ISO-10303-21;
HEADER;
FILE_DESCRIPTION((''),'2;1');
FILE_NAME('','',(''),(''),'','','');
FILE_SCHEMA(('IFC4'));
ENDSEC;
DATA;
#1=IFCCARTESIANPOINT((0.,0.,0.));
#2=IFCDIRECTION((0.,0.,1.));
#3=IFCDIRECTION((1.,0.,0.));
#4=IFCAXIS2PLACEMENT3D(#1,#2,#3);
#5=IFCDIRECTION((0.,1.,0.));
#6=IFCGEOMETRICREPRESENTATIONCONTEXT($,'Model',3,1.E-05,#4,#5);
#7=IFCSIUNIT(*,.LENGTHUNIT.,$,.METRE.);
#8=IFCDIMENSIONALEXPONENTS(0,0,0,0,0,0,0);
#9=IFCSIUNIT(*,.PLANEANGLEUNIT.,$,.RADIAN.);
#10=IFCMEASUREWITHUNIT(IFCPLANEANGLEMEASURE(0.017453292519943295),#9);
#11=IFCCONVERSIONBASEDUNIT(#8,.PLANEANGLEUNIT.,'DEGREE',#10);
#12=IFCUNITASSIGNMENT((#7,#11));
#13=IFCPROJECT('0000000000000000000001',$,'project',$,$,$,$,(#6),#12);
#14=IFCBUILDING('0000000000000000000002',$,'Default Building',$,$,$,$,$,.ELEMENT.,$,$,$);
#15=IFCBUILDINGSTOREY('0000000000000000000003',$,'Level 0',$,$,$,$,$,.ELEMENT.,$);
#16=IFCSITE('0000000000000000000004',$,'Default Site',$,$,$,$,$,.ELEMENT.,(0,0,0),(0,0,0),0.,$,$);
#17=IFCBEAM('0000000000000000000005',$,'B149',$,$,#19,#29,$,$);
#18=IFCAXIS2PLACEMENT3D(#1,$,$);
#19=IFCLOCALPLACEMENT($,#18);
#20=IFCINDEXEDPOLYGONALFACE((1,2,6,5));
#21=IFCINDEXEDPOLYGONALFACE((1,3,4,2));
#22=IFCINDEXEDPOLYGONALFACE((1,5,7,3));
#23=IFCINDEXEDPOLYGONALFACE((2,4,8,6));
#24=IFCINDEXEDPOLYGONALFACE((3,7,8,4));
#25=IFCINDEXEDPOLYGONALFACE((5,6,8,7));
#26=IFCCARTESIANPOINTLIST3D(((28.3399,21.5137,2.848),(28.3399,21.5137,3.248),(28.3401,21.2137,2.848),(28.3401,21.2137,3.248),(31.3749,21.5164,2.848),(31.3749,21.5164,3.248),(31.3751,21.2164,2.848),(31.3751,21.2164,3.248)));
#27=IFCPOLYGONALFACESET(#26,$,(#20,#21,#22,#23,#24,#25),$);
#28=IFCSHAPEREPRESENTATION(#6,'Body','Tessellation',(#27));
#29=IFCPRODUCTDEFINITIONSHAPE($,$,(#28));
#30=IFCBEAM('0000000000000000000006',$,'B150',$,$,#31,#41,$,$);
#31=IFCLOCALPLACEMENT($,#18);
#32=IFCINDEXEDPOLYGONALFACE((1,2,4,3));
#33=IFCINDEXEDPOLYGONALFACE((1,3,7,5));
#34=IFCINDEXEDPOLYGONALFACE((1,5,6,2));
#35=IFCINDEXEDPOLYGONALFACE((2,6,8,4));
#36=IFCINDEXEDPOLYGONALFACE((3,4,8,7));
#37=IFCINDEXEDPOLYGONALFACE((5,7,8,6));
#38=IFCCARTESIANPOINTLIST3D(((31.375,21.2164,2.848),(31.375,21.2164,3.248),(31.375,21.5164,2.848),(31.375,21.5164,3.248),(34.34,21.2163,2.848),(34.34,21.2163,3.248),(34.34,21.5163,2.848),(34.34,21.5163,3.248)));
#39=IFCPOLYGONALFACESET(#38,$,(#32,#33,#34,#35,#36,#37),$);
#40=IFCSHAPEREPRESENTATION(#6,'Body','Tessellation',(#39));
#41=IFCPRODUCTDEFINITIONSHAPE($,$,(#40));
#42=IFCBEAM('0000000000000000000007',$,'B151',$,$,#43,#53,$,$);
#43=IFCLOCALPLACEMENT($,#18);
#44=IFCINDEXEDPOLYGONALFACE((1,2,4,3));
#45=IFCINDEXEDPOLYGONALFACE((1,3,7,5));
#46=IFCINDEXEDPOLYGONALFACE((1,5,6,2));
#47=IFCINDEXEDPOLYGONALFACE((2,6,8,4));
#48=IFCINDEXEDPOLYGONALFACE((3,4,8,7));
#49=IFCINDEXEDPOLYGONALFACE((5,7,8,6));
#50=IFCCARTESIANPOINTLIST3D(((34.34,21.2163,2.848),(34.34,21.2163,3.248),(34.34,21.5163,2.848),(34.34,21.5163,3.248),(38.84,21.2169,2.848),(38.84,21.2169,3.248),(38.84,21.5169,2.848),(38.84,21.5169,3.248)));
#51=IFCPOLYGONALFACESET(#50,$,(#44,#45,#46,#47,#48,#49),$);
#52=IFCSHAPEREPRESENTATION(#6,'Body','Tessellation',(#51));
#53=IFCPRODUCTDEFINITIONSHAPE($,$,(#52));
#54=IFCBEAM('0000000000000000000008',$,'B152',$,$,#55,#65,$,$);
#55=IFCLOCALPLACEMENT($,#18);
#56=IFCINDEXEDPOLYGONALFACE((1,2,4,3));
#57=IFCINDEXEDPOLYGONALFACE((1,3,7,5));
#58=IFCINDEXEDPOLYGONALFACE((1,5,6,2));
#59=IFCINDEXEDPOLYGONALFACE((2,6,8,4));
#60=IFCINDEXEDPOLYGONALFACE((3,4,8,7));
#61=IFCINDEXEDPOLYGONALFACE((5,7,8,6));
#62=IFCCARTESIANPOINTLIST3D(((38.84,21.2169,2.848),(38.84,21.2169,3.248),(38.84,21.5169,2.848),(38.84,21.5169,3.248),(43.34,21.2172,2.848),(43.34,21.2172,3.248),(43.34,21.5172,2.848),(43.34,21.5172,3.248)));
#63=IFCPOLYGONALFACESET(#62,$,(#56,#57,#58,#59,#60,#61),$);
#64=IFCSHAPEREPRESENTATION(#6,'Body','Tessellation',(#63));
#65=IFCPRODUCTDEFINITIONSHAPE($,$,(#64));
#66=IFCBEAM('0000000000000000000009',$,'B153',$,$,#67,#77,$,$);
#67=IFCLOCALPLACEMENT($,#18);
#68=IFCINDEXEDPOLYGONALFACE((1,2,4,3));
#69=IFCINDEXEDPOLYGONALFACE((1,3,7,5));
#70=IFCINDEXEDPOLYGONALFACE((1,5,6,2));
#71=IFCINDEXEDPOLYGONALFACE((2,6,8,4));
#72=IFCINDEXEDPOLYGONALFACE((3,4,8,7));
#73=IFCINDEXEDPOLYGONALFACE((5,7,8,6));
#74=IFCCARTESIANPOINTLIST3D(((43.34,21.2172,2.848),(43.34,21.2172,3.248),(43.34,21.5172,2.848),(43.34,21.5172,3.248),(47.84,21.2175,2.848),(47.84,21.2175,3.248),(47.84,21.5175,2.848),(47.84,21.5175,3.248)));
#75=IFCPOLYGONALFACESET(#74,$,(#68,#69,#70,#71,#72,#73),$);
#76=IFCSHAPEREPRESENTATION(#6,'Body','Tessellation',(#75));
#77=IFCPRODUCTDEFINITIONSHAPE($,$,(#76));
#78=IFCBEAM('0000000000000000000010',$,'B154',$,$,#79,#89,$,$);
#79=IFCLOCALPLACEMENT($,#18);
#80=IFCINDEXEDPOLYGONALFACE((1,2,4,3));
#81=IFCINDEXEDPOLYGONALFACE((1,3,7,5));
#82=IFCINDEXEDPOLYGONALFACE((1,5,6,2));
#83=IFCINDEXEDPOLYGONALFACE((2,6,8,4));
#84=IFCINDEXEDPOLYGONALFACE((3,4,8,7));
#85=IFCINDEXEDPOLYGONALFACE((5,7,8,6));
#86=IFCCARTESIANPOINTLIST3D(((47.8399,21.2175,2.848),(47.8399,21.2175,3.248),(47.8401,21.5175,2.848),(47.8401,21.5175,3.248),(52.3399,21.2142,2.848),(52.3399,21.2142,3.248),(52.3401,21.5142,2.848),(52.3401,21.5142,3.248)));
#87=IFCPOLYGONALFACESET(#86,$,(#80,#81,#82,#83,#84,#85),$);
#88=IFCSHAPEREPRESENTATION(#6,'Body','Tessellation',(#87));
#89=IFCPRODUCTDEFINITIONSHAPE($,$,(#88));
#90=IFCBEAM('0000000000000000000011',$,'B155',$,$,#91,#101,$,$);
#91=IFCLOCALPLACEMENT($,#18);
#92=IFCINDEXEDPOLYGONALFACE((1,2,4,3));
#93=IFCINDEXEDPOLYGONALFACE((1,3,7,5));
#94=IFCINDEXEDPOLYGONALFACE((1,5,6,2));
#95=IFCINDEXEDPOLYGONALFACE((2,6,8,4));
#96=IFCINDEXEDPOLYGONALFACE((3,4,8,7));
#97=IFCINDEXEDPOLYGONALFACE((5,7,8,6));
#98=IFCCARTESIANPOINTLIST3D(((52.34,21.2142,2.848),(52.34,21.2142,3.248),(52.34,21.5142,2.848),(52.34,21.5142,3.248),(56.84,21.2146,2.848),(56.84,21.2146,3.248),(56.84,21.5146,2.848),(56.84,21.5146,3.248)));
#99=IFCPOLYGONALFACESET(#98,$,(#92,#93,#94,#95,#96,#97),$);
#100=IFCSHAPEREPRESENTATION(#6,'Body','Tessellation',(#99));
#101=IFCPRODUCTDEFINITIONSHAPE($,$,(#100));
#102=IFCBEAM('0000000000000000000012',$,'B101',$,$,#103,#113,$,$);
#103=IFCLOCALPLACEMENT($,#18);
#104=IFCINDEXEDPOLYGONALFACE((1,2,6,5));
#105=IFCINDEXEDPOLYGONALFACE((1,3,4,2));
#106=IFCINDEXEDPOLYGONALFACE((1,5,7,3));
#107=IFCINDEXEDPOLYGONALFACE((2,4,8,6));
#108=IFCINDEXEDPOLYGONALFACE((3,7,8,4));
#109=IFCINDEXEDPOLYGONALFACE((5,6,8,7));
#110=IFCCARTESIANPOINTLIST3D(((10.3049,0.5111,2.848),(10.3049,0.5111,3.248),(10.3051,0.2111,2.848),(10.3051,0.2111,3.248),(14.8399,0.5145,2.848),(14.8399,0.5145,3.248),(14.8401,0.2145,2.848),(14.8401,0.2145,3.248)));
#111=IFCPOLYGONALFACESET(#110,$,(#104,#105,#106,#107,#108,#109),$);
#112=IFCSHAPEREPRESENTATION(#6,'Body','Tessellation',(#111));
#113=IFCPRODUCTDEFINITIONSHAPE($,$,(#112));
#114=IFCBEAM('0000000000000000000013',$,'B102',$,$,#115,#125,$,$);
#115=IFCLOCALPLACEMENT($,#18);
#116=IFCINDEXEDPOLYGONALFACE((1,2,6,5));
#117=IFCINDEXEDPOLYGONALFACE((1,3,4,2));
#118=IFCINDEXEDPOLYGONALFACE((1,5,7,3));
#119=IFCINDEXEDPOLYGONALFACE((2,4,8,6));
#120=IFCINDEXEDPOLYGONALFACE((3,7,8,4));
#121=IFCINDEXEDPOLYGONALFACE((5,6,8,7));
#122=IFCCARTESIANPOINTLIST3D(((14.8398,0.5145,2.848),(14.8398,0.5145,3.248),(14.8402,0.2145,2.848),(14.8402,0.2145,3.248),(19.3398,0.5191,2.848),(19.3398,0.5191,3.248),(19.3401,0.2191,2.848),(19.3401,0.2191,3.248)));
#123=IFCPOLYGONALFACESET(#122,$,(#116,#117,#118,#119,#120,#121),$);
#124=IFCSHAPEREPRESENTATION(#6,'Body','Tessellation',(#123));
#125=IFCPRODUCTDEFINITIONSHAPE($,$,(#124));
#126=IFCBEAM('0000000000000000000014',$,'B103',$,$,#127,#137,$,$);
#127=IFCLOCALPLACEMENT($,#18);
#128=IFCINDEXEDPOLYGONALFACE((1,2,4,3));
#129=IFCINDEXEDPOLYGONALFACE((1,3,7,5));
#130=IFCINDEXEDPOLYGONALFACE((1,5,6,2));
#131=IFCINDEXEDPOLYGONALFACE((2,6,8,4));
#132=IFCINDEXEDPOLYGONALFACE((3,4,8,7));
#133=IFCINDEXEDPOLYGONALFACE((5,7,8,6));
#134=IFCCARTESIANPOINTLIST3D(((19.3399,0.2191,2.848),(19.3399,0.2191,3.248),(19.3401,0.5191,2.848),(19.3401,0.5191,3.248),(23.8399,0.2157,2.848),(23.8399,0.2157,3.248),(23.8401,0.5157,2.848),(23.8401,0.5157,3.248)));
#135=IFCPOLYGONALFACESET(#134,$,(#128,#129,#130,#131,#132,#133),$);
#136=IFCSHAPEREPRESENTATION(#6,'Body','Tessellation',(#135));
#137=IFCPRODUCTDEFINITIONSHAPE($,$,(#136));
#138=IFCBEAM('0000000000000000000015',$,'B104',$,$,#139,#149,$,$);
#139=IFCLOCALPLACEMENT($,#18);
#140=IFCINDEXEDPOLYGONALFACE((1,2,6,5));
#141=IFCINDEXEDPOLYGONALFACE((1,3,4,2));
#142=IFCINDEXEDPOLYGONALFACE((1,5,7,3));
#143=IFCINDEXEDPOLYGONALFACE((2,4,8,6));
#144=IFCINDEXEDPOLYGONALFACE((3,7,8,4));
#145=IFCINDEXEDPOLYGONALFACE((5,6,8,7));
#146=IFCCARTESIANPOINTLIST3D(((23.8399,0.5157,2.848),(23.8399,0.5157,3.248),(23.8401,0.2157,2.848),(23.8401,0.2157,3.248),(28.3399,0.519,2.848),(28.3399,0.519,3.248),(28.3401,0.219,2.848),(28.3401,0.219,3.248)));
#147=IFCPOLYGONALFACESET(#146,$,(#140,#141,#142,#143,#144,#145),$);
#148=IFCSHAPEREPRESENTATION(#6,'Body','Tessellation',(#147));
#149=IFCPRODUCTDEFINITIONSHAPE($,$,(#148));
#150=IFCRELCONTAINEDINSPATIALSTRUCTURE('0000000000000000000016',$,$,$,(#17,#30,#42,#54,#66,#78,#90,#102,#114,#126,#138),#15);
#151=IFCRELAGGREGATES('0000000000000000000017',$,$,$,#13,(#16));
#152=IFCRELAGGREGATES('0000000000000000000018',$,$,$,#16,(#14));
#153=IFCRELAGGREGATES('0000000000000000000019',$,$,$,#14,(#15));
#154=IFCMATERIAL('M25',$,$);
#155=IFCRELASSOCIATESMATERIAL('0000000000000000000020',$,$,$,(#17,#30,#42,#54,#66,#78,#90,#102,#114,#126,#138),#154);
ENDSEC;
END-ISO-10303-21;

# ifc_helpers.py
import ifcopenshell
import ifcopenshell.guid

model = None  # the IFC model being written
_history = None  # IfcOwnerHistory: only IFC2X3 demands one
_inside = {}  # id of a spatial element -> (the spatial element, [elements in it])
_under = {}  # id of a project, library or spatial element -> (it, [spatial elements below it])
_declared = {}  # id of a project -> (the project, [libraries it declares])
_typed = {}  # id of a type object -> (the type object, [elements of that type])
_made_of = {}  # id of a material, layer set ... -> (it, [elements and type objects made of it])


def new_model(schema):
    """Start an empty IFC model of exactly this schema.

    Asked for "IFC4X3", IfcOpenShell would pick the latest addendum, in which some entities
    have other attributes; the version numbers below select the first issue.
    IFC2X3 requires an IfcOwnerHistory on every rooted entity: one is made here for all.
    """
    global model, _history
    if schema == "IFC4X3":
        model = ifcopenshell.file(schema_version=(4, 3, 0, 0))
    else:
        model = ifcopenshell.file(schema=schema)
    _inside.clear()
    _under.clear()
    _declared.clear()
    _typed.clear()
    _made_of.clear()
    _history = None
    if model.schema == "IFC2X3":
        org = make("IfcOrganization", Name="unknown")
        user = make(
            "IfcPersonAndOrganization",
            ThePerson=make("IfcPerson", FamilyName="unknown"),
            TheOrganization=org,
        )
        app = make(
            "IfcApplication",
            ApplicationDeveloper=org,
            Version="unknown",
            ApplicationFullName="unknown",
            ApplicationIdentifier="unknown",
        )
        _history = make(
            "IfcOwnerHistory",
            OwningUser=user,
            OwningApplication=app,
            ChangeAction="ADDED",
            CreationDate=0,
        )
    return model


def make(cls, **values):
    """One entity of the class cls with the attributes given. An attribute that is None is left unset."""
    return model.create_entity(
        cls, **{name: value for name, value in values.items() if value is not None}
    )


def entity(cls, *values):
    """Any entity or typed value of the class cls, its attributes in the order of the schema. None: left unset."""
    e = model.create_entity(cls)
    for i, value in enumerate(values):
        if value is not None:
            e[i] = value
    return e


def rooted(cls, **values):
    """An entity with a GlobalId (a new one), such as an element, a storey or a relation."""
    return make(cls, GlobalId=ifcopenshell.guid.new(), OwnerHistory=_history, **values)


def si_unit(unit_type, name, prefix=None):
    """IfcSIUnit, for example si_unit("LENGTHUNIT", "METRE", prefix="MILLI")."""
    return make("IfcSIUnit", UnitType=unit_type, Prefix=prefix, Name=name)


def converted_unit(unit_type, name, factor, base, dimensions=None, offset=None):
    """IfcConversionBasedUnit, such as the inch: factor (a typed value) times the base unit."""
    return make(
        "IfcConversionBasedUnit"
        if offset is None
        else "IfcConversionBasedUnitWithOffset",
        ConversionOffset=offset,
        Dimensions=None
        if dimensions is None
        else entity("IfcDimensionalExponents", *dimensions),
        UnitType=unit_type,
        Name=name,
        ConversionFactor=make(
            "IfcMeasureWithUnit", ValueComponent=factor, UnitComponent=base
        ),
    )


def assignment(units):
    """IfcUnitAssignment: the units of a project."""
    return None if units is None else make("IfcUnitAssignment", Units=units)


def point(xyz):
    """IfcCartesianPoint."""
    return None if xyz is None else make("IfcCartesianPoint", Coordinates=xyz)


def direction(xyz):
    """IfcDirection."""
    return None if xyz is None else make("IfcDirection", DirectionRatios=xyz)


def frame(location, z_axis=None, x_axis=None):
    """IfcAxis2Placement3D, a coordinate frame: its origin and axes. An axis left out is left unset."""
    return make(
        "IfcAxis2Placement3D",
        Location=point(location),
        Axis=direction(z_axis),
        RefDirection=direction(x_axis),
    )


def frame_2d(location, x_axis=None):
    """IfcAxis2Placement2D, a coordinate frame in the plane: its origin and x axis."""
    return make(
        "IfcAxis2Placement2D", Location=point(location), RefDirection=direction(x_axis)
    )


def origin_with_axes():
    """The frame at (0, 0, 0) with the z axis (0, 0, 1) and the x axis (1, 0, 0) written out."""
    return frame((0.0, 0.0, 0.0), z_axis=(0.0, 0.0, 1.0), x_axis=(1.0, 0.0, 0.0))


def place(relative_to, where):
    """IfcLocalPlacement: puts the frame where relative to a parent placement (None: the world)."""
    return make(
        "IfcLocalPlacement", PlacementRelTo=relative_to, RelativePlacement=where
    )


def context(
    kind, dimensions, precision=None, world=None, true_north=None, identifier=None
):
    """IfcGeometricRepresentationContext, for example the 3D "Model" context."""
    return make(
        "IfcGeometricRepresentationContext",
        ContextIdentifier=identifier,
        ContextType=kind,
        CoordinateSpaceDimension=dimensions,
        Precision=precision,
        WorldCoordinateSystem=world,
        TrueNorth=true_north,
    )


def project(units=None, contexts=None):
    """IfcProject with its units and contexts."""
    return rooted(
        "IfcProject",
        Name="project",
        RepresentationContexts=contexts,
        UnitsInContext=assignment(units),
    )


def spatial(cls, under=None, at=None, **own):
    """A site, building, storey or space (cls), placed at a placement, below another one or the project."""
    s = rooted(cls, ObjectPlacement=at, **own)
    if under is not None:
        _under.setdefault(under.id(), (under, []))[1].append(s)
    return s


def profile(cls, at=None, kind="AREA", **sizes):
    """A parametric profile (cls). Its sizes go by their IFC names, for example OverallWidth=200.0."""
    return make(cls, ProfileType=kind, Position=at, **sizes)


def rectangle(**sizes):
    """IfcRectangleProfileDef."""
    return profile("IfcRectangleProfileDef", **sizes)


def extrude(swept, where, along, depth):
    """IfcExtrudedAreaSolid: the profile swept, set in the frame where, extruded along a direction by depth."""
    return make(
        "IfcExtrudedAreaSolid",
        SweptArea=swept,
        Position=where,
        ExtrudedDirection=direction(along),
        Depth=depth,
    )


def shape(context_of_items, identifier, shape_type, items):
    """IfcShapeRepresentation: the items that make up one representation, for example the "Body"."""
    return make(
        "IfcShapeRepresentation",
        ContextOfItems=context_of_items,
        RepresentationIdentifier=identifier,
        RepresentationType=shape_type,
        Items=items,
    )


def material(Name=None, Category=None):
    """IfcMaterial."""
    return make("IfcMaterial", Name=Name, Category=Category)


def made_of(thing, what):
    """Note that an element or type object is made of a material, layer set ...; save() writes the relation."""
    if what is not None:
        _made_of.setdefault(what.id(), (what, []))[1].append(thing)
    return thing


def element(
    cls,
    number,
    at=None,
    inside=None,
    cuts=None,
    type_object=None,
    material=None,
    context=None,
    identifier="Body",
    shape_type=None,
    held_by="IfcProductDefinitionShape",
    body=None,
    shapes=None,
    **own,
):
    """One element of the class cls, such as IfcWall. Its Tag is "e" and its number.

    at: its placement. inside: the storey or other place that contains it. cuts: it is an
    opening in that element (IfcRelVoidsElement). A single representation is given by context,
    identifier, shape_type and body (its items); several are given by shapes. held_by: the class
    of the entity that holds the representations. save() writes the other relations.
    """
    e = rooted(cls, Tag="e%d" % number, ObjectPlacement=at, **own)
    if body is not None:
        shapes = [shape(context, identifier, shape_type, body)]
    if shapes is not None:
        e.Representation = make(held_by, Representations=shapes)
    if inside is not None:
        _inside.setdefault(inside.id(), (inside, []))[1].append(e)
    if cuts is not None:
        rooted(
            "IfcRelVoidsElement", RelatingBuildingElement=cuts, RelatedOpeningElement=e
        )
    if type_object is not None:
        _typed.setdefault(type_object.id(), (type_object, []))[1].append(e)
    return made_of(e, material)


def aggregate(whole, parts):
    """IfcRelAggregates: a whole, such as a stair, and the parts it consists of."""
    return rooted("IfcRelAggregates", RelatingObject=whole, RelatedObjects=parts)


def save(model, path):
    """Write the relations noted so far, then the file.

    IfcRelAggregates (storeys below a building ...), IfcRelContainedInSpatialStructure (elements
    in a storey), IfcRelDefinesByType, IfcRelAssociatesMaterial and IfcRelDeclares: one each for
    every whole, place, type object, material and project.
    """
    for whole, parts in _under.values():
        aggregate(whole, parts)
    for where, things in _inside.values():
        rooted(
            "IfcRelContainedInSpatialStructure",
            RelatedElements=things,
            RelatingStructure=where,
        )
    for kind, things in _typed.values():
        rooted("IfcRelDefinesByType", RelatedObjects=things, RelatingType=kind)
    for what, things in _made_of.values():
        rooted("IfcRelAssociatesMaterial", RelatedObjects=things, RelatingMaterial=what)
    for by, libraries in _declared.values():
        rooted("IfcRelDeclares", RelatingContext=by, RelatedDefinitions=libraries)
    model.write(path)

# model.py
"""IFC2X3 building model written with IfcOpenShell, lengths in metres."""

from ifc_helpers import new_model, entity, si_unit, converted_unit, direction, frame, frame_2d, origin_with_axes, place, context, project, spatial, rectangle, extrude, material, element, save


model = new_model("IFC2X3")

# Units and contexts
model_context = context("Model", 3, precision=1e-05, world=origin_with_axes(), true_north=direction((0.0, 1.0, 0.0)))
ifc_project = project(units=[si_unit("LENGTHUNIT", "METRE"), converted_unit("PLANEANGLEUNIT", "DEGREE", entity("IfcPlaneAngleMeasure", 0.017453292519943295), si_unit("PLANEANGLEUNIT", "RADIAN"), dimensions=[0, 0, 0, 0, 0, 0, 0])], contexts=[model_context])

# Site, building, storey
site = spatial("IfcSite", under=ifc_project, Name="Default Site", CompositionType="ELEMENT", RefLatitude=(0, 0, 0), RefLongitude=(0, 0, 0), RefElevation=0.0)
building = spatial("IfcBuilding", under=site, Name="Default Building", CompositionType="ELEMENT")
storey = spatial("IfcBuildingStorey", under=building, Name="Level 0", CompositionType="ELEMENT")

# Shared definitions
ifc_material = material(Name="M25")
placement = place(None, origin_with_axes())

# Beams
element("IfcBeam", 1, at=placement, inside=storey, material=ifc_material, Name="B149", context=model_context, shape_type="SweptSolid", body=[
    extrude(rectangle(XDim=0.3, YDim=0.4, at=frame_2d((0.0, 0.0), x_axis=(0.0, 1.0, 0.0))), frame((28.34, 21.3637, 3.048), z_axis=(1.0, 0.000883, 0.0), x_axis=(0.0, 0.0, -1.0)), (0.0, 0.0, 1.0), 3.035),
])
element("IfcBeam", 2, at=placement, inside=storey, material=ifc_material, Name="B150", context=model_context, shape_type="SweptSolid", body=[
    extrude(rectangle(XDim=0.3, YDim=0.4, at=frame_2d((0.0, 0.0), x_axis=(0.0, 1.0, 0.0))), frame((31.375, 21.3664, 3.048), z_axis=(1.0, -0.000016, 0.0), x_axis=(0.0, 0.0, -1.0)), (0.0, 0.0, 1.0), 2.965),
])
element("IfcBeam", 3, at=placement, inside=storey, material=ifc_material, Name="B151", context=model_context, shape_type="SweptSolid", body=[
    extrude(rectangle(XDim=0.3, YDim=0.4, at=frame_2d((0.0, 0.0), x_axis=(0.0, 1.0, 0.0))), frame((34.34, 21.3663, 3.048), z_axis=(1.0, 0.000136, 0.0), x_axis=(0.0, 0.0, -1.0)), (0.0, 0.0, 1.0), 4.5),
])
element("IfcBeam", 4, at=placement, inside=storey, material=ifc_material, Name="B152", context=model_context, shape_type="SweptSolid", body=[
    extrude(rectangle(XDim=0.3, YDim=0.4, at=frame_2d((0.0, 0.0), x_axis=(0.0, 1.0, 0.0))), frame((38.84, 21.3669, 3.048), z_axis=(1.0, 0.00005, 0.0), x_axis=(0.0, 0.0, -1.0)), (0.0, 0.0, 1.0), 4.5),
])
element("IfcBeam", 5, at=placement, inside=storey, material=ifc_material, Name="B153", context=model_context, shape_type="SweptSolid", body=[
    extrude(rectangle(XDim=0.3, YDim=0.4, at=frame_2d((0.0, 0.0), x_axis=(0.0, 1.0, 0.0))), frame((43.34, 21.3672, 3.048), z_axis=(1.0, 0.000075, 0.0), x_axis=(0.0, 0.0, -1.0)), (0.0, 0.0, 1.0), 4.5),
])
element("IfcBeam", 6, at=placement, inside=storey, material=ifc_material, Name="B154", context=model_context, shape_type="SweptSolid", body=[
    extrude(rectangle(XDim=0.3, YDim=0.4, at=frame_2d((0.0, 0.0), x_axis=(0.0, 1.0, 0.0))), frame((47.84, 21.3675, 3.048), z_axis=(1.0, -0.000744, 0.0), x_axis=(0.0, 0.0, -1.0)), (0.0, 0.0, 1.0), 4.5),
])
element("IfcBeam", 7, at=placement, inside=storey, material=ifc_material, Name="B155", context=model_context, shape_type="SweptSolid", body=[
    extrude(rectangle(XDim=0.3, YDim=0.4, at=frame_2d((0.0, 0.0), x_axis=(0.0, 1.0, 0.0))), frame((52.34, 21.3642, 3.048), z_axis=(1.0, 0.000102, 0.0), x_axis=(0.0, 0.0, -1.0)), (0.0, 0.0, 1.0), 4.5),
])
element("IfcBeam", 8, at=placement, inside=storey, material=ifc_material, Name="B101", context=model_context, shape_type="SweptSolid", body=[
    extrude(rectangle(XDim=0.3, YDim=0.4, at=frame_2d((0.0, 0.0), x_axis=(0.0, 1.0, 0.0))), frame((10.305, 0.3611, 3.048), z_axis=(1.0, 0.000762, 0.0), x_axis=(0.0, 0.0, -1.0)), (0.0, 0.0, 1.0), 4.535),
])
element("IfcBeam", 9, at=placement, inside=storey, material=ifc_material, Name="B102", context=model_context, shape_type="SweptSolid", body=[
    extrude(rectangle(XDim=0.3, YDim=0.4, at=frame_2d((0.0, 0.0), x_axis=(0.0, 1.0, 0.0))), frame((14.84, 0.3645, 3.048), z_axis=(0.999999, 0.00101, 0.0), x_axis=(0.0, 0.0, -1.0)), (0.0, 0.0, 1.0), 4.5),
])
element("IfcBeam", 10, at=placement, inside=storey, material=ifc_material, Name="B103", context=model_context, shape_type="SweptSolid", body=[
    extrude(rectangle(XDim=0.3, YDim=0.4, at=frame_2d((0.0, 0.0), x_axis=(0.0, 1.0, 0.0))), frame((19.34, 0.3691, 3.048), z_axis=(1.0, -0.000757, 0.0), x_axis=(0.0, 0.0, -1.0)), (0.0, 0.0, 1.0), 4.5),
])
element("IfcBeam", 11, at=placement, inside=storey, material=ifc_material, Name="B104", context=model_context, shape_type="SweptSolid", body=[
    extrude(rectangle(XDim=0.3, YDim=0.4, at=frame_2d((0.0, 0.0), x_axis=(0.0, 1.0, 0.0))), frame((23.84, 0.3657, 3.048), z_axis=(1.0, 0.00075, 0.0), x_axis=(0.0, 0.0, -1.0)), (0.0, 0.0, 1.0), 4.5),
])

save(model, "model.ifc")
